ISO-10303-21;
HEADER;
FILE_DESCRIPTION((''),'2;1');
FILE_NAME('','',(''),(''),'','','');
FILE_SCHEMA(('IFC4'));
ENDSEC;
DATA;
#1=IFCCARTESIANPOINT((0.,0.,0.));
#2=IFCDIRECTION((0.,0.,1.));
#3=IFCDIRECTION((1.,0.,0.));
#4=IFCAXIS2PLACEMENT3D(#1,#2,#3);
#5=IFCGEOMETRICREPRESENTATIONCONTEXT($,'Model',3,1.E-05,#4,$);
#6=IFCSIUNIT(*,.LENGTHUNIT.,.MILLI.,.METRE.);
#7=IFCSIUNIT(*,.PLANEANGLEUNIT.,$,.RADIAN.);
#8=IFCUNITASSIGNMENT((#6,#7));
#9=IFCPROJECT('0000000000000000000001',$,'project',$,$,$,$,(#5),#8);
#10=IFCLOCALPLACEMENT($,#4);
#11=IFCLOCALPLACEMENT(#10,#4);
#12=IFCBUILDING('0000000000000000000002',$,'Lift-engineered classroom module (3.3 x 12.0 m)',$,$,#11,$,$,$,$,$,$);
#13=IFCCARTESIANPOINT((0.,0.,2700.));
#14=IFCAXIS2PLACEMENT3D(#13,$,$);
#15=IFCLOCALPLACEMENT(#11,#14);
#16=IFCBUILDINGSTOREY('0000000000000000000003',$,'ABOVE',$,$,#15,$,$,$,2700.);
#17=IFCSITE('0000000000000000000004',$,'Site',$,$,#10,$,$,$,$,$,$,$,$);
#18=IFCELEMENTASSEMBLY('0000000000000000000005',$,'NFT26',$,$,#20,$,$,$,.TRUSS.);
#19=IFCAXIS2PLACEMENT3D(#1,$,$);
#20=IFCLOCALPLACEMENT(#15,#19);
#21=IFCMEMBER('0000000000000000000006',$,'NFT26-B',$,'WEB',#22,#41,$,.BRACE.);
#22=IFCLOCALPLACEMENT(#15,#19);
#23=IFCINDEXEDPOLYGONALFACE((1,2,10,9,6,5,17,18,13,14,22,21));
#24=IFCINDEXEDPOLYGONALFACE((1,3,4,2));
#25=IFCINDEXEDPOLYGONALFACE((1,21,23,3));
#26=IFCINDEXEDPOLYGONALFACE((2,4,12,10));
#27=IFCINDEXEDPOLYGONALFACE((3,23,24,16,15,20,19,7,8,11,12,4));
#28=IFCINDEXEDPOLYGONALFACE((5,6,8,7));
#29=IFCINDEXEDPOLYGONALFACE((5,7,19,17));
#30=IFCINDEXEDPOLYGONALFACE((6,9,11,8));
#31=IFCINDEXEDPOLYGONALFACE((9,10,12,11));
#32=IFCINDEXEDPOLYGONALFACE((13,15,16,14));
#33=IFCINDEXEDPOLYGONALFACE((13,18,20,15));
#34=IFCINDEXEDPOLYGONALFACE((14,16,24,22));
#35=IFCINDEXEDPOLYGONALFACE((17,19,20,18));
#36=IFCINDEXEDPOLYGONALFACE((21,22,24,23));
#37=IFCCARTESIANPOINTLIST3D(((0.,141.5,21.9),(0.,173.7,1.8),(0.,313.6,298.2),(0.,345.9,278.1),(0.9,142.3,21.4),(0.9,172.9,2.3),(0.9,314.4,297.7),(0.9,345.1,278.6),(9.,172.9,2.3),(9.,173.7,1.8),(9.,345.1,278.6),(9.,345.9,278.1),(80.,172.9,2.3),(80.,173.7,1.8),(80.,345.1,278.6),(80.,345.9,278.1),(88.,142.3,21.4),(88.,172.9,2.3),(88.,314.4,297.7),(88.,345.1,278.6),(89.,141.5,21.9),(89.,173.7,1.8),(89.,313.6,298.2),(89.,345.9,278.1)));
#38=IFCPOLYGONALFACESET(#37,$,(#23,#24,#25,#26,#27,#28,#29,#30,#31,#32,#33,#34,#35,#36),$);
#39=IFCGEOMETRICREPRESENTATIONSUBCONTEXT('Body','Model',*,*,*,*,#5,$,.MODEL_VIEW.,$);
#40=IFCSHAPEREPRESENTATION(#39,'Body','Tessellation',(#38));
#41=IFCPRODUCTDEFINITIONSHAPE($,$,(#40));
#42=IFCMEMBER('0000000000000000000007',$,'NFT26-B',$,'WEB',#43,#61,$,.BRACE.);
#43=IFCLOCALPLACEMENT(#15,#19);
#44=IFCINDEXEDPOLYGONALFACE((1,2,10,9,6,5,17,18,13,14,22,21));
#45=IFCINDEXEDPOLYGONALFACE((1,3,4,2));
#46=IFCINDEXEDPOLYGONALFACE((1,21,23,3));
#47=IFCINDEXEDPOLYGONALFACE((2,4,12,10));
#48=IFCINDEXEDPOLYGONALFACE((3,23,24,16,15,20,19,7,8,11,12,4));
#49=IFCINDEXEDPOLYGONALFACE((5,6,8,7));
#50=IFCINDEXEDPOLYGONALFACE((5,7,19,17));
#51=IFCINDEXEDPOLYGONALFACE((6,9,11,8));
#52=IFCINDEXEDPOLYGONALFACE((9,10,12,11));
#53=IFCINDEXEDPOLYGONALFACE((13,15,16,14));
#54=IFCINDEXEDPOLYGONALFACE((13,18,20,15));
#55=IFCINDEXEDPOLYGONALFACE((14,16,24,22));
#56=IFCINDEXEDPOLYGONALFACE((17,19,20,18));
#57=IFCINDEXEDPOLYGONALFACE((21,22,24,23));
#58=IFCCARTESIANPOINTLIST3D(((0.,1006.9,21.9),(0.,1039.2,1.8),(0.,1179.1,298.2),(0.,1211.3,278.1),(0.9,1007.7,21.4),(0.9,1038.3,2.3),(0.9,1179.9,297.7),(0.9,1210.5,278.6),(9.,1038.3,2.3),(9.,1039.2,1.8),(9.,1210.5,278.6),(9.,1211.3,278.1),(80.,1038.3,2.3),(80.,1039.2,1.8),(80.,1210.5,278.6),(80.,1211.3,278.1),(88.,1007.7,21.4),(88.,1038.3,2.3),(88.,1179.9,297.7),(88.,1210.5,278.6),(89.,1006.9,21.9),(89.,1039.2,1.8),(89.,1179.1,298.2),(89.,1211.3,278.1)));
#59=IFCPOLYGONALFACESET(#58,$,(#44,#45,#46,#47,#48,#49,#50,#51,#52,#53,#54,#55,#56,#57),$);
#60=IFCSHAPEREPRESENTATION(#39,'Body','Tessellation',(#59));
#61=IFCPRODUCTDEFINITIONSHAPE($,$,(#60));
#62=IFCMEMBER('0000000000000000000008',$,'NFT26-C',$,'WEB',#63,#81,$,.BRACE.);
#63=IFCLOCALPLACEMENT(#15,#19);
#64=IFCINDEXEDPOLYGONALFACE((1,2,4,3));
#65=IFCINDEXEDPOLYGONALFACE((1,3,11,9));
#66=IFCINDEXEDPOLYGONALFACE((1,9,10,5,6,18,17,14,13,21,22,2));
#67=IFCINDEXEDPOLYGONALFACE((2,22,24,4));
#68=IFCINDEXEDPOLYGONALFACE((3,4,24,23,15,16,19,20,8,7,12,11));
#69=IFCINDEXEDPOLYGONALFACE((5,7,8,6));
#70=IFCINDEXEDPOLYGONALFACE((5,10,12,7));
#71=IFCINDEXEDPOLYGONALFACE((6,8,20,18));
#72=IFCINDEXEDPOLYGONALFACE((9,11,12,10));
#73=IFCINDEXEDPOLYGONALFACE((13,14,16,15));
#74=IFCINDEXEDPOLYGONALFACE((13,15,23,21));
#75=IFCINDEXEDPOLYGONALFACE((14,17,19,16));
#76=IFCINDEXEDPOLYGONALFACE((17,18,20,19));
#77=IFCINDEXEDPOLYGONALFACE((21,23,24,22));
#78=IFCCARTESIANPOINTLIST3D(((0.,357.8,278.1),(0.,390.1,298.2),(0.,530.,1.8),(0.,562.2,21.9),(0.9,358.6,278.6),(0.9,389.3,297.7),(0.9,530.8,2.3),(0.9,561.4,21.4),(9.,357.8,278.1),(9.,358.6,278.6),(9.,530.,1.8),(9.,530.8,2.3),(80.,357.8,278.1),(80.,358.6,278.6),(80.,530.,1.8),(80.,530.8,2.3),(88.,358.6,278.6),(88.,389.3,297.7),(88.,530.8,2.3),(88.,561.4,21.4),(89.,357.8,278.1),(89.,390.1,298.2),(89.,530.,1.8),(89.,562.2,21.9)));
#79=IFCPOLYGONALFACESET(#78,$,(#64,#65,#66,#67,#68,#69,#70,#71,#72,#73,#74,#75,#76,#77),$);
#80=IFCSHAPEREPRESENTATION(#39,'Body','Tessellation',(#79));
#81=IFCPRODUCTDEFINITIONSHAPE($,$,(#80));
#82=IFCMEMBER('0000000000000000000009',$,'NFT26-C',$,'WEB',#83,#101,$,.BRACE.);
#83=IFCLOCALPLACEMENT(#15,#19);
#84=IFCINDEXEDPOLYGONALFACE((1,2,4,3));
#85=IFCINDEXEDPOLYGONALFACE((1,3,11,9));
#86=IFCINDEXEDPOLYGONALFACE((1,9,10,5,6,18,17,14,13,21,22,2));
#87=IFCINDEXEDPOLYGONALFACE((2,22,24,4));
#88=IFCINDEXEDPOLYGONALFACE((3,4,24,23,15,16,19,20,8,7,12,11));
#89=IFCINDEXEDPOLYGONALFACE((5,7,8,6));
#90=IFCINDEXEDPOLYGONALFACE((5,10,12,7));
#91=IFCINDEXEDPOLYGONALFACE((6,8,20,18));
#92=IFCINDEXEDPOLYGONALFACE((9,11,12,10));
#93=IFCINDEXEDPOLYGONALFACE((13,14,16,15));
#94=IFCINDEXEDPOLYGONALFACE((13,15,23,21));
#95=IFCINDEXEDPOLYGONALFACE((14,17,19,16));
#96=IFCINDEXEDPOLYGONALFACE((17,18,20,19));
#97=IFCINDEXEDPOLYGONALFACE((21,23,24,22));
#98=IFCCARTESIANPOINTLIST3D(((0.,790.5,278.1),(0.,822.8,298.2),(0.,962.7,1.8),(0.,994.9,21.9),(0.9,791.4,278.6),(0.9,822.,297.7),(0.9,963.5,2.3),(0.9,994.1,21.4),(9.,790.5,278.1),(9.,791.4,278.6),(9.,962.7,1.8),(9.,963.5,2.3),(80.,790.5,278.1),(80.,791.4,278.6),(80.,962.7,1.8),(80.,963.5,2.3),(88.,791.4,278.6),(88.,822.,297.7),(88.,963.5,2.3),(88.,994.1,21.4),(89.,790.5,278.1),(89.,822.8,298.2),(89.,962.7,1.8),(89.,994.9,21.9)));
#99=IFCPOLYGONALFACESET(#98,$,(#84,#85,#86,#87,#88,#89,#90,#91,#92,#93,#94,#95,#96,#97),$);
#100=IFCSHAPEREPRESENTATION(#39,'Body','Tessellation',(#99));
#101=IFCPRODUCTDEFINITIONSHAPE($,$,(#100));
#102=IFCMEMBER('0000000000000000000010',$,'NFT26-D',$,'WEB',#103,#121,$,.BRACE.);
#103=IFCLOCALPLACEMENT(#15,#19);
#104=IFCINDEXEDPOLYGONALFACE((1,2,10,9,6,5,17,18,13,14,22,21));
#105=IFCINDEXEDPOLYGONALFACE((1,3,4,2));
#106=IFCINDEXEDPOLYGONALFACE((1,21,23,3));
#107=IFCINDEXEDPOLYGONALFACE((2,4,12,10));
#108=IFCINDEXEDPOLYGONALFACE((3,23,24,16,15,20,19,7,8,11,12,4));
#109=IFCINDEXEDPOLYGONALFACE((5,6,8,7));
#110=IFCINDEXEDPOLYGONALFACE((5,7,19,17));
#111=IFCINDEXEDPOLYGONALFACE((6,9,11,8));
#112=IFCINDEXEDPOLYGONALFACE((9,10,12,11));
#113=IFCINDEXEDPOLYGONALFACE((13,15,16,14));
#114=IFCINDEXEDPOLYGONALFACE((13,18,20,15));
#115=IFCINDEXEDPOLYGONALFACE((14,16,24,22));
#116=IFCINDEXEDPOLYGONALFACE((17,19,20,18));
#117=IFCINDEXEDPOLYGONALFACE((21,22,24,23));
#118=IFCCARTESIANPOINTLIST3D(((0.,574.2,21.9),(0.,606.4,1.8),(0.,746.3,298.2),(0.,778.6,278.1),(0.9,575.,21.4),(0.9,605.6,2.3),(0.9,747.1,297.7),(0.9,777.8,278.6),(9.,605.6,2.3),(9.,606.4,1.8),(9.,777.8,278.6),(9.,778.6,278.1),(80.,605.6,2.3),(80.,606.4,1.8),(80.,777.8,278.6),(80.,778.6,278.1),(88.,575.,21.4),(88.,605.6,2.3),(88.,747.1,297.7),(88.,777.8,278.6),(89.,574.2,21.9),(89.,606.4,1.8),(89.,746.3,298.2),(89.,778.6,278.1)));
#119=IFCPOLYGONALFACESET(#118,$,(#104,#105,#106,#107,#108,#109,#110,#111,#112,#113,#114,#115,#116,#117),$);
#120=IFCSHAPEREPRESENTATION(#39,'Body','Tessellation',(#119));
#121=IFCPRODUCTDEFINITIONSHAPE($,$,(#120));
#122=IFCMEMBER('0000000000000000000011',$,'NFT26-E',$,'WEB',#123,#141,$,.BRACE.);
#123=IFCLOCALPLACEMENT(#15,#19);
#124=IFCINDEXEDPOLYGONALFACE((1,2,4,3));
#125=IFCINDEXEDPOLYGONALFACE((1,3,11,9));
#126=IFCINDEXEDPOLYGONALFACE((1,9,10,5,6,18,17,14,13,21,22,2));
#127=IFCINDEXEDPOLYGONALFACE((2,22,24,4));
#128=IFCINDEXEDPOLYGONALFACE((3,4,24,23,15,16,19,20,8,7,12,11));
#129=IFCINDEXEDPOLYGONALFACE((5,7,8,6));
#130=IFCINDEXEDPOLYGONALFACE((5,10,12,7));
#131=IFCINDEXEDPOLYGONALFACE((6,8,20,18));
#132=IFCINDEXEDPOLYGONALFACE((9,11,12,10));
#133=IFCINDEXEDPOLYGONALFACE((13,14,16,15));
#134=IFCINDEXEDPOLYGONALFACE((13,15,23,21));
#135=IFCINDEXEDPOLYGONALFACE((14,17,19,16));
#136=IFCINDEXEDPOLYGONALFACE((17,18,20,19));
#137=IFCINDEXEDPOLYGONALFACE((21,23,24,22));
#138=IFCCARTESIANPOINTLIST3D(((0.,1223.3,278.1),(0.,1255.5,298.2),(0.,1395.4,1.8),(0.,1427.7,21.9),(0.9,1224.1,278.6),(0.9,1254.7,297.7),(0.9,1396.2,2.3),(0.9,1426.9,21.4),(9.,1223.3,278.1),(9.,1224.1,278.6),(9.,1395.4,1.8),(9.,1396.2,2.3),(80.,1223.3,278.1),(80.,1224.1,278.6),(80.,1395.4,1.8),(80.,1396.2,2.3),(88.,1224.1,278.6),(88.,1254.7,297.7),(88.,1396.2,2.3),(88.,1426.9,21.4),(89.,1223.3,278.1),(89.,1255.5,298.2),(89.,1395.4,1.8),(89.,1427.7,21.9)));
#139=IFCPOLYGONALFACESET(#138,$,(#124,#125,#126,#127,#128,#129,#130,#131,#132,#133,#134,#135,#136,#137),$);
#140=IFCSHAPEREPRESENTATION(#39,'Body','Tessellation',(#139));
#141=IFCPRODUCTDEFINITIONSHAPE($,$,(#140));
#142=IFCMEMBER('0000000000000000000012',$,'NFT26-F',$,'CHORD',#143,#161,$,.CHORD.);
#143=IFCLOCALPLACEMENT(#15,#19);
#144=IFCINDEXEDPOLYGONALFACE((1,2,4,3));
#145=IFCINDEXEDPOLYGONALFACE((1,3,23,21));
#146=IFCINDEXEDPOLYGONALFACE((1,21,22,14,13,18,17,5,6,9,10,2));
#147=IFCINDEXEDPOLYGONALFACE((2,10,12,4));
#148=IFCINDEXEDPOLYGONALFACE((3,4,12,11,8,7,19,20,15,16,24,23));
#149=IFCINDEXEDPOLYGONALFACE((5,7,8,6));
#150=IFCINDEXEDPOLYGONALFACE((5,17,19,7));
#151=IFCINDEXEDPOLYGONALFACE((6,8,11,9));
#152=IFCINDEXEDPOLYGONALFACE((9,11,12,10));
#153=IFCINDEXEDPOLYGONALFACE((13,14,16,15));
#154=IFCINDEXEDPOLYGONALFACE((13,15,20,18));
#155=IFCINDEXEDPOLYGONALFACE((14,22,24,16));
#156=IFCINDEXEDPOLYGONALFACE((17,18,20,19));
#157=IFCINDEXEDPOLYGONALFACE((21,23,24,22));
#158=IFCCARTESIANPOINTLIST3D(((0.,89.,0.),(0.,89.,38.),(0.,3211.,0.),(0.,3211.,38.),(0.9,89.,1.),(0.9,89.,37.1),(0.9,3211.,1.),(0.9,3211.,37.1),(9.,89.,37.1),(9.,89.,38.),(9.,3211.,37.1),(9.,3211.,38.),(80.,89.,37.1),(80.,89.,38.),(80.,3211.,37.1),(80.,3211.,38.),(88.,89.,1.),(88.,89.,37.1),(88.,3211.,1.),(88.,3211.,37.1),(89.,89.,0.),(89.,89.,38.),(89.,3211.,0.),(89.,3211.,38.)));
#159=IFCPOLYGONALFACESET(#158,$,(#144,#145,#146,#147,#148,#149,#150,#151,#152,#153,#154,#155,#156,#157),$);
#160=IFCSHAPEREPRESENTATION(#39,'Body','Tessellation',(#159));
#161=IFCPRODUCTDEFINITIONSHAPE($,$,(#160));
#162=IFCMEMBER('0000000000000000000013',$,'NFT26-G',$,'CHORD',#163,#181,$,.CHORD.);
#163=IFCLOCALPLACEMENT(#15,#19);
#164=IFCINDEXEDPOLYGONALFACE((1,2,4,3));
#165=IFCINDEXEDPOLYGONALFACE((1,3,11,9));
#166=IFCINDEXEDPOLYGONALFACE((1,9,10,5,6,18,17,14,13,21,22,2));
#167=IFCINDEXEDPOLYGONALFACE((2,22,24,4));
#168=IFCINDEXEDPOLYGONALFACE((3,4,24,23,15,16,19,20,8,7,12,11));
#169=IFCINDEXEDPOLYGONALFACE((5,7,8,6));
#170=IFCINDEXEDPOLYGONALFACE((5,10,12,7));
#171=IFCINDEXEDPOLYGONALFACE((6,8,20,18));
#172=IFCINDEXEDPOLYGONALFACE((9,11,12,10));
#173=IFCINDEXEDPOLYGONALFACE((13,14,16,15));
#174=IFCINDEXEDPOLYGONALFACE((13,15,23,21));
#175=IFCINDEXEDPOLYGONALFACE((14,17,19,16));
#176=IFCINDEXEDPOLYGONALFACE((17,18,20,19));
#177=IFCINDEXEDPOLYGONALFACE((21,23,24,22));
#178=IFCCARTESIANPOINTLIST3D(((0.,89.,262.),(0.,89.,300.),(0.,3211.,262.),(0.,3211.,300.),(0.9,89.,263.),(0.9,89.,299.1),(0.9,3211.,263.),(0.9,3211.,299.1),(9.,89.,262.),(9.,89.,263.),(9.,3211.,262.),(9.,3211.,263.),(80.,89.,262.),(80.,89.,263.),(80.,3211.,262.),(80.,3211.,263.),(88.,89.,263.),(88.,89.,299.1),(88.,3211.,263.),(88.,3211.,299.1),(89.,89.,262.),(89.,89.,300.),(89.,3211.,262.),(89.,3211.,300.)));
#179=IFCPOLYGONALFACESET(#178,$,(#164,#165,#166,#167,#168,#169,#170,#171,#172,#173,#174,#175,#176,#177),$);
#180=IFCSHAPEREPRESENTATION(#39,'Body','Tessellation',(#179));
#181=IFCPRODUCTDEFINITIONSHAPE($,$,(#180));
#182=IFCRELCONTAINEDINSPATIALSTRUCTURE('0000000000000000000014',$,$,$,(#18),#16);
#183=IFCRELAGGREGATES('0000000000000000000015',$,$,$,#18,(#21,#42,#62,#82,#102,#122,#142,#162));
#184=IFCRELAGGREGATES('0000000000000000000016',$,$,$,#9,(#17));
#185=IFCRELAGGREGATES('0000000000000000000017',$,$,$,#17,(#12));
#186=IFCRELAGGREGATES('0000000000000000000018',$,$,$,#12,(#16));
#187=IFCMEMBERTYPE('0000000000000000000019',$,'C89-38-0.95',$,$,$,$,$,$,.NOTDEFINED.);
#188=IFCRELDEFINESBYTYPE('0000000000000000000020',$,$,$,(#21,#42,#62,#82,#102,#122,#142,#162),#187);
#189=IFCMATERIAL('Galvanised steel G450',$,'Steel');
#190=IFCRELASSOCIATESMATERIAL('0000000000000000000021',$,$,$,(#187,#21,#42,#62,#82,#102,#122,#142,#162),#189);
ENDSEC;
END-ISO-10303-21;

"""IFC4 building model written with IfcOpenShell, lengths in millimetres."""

from ifc_helpers import new_model, si_unit, frame, origin, origin_with_axes, origin_2d, place, context, subcontext, project, spatial, c_section, extrude, material, material_profile, profile_set, profile_usage, type_object, element, aggregate, save


model = new_model("IFC4")

# Units and contexts
model_context = context("Model", 3, precision=1e-05, world=origin_with_axes())
body_context = subcontext(model_context, "Body", "Model", "MODEL_VIEW")
ifc_project = project(units=[si_unit("LENGTHUNIT", "METRE", prefix="MILLI"), si_unit("PLANEANGLEUNIT", "RADIAN")], contexts=[model_context])

# Site, building, storey
site_placement = place(None, origin_with_axes())
site = spatial("IfcSite", under=ifc_project, at=site_placement, Name="Site")
building_placement = place(site_placement, origin_with_axes())
building = spatial("IfcBuilding", under=site, at=building_placement, Name="Lift-engineered classroom module (3.3 x 12.0 m)")
storey_placement = place(building_placement, frame((0.0, 0.0, 2700.0)))
storey = spatial("IfcBuildingStorey", under=building, at=storey_placement, Name="ABOVE", Elevation=2700.0)

# Element assembly, members
ifc_material = material(Name="Galvanised steel G450", Category="Steel")
ifc_material_profile = material_profile(ifc_material, c_section(Depth=89.0, Width=38.0, WallThickness=0.9, Girth=9.0, at=origin_2d()), Name="C89-38-0.95")
ifc_profile_set = profile_set([ifc_material_profile], Name="C89-38-0.95")
ifc_profile_usage = profile_usage(ifc_profile_set)
member_type = type_object("IfcMemberType", Name="C89-38-0.95", PredefinedType="NOTDEFINED", material=ifc_profile_set)
assembly_1_placement = place(storey_placement, frame((44.5, 89.0, 0.0)))
assembly_1 = element("IfcElementAssembly", 1, at=assembly_1_placement, inside=storey, Name="NFT26", PredefinedType="TRUSS")
member_1_placement = place(assembly_1_placement, frame((0.0, 68.6, 11.8), z_axis=(0.0, 0.528797, 0.848748), x_axis=(0.0, 0.848748, -0.528797)))
member_1 = element("IfcMember", 2, at=member_1_placement, type_object=member_type, material=ifc_profile_usage, Name="NFT26-B", ObjectType="WEB", PredefinedType="BRACE", context=body_context, shape_type="SweptSolid", body=[
    extrude(c_section(Depth=89.0, Width=38.0, WallThickness=0.9, Girth=9.0, at=origin_2d()), origin(), (0.0, 0.0, 1.0), 325.6),
])
member_2_placement = place(assembly_1_placement, frame((0.0, 934.0, 11.8), z_axis=(0.0, 0.528797, 0.848748), x_axis=(0.0, 0.848748, -0.528797)))
member_2 = element("IfcMember", 3, at=member_2_placement, type_object=member_type, material=ifc_profile_usage, Name="NFT26-B", ObjectType="WEB", PredefinedType="BRACE", context=body_context, shape_type="SweptSolid", body=[
    extrude(c_section(Depth=89.0, Width=38.0, WallThickness=0.9, Girth=9.0, at=origin_2d()), origin(), (0.0, 0.0, 1.0), 325.6),
])
member_3_placement = place(assembly_1_placement, frame((0.0, 457.1, 11.8), z_axis=(0.0, -0.528797, 0.848748), x_axis=(0.0, -0.848748, -0.528797)))
member_3 = element("IfcMember", 4, at=member_3_placement, type_object=member_type, material=ifc_profile_usage, Name="NFT26-C", ObjectType="WEB", PredefinedType="BRACE", context=body_context, shape_type="SweptSolid", body=[
    extrude(c_section(Depth=89.0, Width=38.0, WallThickness=0.9, Girth=9.0, at=origin_2d()), origin(), (0.0, 0.0, 1.0), 325.6),
])
member_4_placement = place(assembly_1_placement, frame((0.0, 889.8, 11.8), z_axis=(0.0, -0.528797, 0.848748), x_axis=(0.0, -0.848748, -0.528797)))
member_4 = element("IfcMember", 5, at=member_4_placement, type_object=member_type, material=ifc_profile_usage, Name="NFT26-C", ObjectType="WEB", PredefinedType="BRACE", context=body_context, shape_type="SweptSolid", body=[
    extrude(c_section(Depth=89.0, Width=38.0, WallThickness=0.9, Girth=9.0, at=origin_2d()), origin(), (0.0, 0.0, 1.0), 325.6),
])
member_5_placement = place(assembly_1_placement, frame((0.0, 501.3, 11.8), z_axis=(0.0, 0.528775, 0.848762), x_axis=(0.0, 0.848762, -0.528775)))
member_5 = element("IfcMember", 6, at=member_5_placement, type_object=member_type, material=ifc_profile_usage, Name="NFT26-D", ObjectType="WEB", PredefinedType="BRACE", context=body_context, shape_type="SweptSolid", body=[
    extrude(c_section(Depth=89.0, Width=38.0, WallThickness=0.9, Girth=9.0, at=origin_2d()), origin(), (0.0, 0.0, 1.0), 325.6),
])
member_6_placement = place(assembly_1_placement, frame((0.0, 1322.5, 11.8), z_axis=(0.0, -0.528775, 0.848762), x_axis=(0.0, -0.848762, -0.528775)))
member_6 = element("IfcMember", 7, at=member_6_placement, type_object=member_type, material=ifc_profile_usage, Name="NFT26-E", ObjectType="WEB", PredefinedType="BRACE", context=body_context, shape_type="SweptSolid", body=[
    extrude(c_section(Depth=89.0, Width=38.0, WallThickness=0.9, Girth=9.0, at=origin_2d()), origin(), (0.0, 0.0, 1.0), 325.6),
])
member_7_placement = place(assembly_1_placement, frame((0.0, 0.0, 19.0), z_axis=(0.0, 1.0, 0.0), x_axis=(0.0, 0.0, 1.0)))
member_7 = element("IfcMember", 8, at=member_7_placement, type_object=member_type, material=ifc_profile_usage, Name="NFT26-F", ObjectType="CHORD", PredefinedType="CHORD", context=body_context, shape_type="SweptSolid", body=[
    extrude(c_section(Depth=89.0, Width=38.0, WallThickness=0.9, Girth=9.0, at=origin_2d()), origin(), (0.0, 0.0, 1.0), 3122.0),
])
member_8_placement = place(assembly_1_placement, frame((0.0, 0.0, 281.0), z_axis=(0.0, 1.0, 0.0), x_axis=(0.0, 0.0, -1.0)))
member_8 = element("IfcMember", 9, at=member_8_placement, type_object=member_type, material=ifc_profile_usage, Name="NFT26-G", ObjectType="CHORD", PredefinedType="CHORD", context=body_context, shape_type="SweptSolid", body=[
    extrude(c_section(Depth=89.0, Width=38.0, WallThickness=0.9, Girth=9.0, at=origin_2d()), origin(), (0.0, 0.0, 1.0), 3122.0),
])
aggregate(assembly_1, [member_1, member_2, member_3, member_4, member_5, member_6, member_7, member_8])

save(model, "model.ifc")
